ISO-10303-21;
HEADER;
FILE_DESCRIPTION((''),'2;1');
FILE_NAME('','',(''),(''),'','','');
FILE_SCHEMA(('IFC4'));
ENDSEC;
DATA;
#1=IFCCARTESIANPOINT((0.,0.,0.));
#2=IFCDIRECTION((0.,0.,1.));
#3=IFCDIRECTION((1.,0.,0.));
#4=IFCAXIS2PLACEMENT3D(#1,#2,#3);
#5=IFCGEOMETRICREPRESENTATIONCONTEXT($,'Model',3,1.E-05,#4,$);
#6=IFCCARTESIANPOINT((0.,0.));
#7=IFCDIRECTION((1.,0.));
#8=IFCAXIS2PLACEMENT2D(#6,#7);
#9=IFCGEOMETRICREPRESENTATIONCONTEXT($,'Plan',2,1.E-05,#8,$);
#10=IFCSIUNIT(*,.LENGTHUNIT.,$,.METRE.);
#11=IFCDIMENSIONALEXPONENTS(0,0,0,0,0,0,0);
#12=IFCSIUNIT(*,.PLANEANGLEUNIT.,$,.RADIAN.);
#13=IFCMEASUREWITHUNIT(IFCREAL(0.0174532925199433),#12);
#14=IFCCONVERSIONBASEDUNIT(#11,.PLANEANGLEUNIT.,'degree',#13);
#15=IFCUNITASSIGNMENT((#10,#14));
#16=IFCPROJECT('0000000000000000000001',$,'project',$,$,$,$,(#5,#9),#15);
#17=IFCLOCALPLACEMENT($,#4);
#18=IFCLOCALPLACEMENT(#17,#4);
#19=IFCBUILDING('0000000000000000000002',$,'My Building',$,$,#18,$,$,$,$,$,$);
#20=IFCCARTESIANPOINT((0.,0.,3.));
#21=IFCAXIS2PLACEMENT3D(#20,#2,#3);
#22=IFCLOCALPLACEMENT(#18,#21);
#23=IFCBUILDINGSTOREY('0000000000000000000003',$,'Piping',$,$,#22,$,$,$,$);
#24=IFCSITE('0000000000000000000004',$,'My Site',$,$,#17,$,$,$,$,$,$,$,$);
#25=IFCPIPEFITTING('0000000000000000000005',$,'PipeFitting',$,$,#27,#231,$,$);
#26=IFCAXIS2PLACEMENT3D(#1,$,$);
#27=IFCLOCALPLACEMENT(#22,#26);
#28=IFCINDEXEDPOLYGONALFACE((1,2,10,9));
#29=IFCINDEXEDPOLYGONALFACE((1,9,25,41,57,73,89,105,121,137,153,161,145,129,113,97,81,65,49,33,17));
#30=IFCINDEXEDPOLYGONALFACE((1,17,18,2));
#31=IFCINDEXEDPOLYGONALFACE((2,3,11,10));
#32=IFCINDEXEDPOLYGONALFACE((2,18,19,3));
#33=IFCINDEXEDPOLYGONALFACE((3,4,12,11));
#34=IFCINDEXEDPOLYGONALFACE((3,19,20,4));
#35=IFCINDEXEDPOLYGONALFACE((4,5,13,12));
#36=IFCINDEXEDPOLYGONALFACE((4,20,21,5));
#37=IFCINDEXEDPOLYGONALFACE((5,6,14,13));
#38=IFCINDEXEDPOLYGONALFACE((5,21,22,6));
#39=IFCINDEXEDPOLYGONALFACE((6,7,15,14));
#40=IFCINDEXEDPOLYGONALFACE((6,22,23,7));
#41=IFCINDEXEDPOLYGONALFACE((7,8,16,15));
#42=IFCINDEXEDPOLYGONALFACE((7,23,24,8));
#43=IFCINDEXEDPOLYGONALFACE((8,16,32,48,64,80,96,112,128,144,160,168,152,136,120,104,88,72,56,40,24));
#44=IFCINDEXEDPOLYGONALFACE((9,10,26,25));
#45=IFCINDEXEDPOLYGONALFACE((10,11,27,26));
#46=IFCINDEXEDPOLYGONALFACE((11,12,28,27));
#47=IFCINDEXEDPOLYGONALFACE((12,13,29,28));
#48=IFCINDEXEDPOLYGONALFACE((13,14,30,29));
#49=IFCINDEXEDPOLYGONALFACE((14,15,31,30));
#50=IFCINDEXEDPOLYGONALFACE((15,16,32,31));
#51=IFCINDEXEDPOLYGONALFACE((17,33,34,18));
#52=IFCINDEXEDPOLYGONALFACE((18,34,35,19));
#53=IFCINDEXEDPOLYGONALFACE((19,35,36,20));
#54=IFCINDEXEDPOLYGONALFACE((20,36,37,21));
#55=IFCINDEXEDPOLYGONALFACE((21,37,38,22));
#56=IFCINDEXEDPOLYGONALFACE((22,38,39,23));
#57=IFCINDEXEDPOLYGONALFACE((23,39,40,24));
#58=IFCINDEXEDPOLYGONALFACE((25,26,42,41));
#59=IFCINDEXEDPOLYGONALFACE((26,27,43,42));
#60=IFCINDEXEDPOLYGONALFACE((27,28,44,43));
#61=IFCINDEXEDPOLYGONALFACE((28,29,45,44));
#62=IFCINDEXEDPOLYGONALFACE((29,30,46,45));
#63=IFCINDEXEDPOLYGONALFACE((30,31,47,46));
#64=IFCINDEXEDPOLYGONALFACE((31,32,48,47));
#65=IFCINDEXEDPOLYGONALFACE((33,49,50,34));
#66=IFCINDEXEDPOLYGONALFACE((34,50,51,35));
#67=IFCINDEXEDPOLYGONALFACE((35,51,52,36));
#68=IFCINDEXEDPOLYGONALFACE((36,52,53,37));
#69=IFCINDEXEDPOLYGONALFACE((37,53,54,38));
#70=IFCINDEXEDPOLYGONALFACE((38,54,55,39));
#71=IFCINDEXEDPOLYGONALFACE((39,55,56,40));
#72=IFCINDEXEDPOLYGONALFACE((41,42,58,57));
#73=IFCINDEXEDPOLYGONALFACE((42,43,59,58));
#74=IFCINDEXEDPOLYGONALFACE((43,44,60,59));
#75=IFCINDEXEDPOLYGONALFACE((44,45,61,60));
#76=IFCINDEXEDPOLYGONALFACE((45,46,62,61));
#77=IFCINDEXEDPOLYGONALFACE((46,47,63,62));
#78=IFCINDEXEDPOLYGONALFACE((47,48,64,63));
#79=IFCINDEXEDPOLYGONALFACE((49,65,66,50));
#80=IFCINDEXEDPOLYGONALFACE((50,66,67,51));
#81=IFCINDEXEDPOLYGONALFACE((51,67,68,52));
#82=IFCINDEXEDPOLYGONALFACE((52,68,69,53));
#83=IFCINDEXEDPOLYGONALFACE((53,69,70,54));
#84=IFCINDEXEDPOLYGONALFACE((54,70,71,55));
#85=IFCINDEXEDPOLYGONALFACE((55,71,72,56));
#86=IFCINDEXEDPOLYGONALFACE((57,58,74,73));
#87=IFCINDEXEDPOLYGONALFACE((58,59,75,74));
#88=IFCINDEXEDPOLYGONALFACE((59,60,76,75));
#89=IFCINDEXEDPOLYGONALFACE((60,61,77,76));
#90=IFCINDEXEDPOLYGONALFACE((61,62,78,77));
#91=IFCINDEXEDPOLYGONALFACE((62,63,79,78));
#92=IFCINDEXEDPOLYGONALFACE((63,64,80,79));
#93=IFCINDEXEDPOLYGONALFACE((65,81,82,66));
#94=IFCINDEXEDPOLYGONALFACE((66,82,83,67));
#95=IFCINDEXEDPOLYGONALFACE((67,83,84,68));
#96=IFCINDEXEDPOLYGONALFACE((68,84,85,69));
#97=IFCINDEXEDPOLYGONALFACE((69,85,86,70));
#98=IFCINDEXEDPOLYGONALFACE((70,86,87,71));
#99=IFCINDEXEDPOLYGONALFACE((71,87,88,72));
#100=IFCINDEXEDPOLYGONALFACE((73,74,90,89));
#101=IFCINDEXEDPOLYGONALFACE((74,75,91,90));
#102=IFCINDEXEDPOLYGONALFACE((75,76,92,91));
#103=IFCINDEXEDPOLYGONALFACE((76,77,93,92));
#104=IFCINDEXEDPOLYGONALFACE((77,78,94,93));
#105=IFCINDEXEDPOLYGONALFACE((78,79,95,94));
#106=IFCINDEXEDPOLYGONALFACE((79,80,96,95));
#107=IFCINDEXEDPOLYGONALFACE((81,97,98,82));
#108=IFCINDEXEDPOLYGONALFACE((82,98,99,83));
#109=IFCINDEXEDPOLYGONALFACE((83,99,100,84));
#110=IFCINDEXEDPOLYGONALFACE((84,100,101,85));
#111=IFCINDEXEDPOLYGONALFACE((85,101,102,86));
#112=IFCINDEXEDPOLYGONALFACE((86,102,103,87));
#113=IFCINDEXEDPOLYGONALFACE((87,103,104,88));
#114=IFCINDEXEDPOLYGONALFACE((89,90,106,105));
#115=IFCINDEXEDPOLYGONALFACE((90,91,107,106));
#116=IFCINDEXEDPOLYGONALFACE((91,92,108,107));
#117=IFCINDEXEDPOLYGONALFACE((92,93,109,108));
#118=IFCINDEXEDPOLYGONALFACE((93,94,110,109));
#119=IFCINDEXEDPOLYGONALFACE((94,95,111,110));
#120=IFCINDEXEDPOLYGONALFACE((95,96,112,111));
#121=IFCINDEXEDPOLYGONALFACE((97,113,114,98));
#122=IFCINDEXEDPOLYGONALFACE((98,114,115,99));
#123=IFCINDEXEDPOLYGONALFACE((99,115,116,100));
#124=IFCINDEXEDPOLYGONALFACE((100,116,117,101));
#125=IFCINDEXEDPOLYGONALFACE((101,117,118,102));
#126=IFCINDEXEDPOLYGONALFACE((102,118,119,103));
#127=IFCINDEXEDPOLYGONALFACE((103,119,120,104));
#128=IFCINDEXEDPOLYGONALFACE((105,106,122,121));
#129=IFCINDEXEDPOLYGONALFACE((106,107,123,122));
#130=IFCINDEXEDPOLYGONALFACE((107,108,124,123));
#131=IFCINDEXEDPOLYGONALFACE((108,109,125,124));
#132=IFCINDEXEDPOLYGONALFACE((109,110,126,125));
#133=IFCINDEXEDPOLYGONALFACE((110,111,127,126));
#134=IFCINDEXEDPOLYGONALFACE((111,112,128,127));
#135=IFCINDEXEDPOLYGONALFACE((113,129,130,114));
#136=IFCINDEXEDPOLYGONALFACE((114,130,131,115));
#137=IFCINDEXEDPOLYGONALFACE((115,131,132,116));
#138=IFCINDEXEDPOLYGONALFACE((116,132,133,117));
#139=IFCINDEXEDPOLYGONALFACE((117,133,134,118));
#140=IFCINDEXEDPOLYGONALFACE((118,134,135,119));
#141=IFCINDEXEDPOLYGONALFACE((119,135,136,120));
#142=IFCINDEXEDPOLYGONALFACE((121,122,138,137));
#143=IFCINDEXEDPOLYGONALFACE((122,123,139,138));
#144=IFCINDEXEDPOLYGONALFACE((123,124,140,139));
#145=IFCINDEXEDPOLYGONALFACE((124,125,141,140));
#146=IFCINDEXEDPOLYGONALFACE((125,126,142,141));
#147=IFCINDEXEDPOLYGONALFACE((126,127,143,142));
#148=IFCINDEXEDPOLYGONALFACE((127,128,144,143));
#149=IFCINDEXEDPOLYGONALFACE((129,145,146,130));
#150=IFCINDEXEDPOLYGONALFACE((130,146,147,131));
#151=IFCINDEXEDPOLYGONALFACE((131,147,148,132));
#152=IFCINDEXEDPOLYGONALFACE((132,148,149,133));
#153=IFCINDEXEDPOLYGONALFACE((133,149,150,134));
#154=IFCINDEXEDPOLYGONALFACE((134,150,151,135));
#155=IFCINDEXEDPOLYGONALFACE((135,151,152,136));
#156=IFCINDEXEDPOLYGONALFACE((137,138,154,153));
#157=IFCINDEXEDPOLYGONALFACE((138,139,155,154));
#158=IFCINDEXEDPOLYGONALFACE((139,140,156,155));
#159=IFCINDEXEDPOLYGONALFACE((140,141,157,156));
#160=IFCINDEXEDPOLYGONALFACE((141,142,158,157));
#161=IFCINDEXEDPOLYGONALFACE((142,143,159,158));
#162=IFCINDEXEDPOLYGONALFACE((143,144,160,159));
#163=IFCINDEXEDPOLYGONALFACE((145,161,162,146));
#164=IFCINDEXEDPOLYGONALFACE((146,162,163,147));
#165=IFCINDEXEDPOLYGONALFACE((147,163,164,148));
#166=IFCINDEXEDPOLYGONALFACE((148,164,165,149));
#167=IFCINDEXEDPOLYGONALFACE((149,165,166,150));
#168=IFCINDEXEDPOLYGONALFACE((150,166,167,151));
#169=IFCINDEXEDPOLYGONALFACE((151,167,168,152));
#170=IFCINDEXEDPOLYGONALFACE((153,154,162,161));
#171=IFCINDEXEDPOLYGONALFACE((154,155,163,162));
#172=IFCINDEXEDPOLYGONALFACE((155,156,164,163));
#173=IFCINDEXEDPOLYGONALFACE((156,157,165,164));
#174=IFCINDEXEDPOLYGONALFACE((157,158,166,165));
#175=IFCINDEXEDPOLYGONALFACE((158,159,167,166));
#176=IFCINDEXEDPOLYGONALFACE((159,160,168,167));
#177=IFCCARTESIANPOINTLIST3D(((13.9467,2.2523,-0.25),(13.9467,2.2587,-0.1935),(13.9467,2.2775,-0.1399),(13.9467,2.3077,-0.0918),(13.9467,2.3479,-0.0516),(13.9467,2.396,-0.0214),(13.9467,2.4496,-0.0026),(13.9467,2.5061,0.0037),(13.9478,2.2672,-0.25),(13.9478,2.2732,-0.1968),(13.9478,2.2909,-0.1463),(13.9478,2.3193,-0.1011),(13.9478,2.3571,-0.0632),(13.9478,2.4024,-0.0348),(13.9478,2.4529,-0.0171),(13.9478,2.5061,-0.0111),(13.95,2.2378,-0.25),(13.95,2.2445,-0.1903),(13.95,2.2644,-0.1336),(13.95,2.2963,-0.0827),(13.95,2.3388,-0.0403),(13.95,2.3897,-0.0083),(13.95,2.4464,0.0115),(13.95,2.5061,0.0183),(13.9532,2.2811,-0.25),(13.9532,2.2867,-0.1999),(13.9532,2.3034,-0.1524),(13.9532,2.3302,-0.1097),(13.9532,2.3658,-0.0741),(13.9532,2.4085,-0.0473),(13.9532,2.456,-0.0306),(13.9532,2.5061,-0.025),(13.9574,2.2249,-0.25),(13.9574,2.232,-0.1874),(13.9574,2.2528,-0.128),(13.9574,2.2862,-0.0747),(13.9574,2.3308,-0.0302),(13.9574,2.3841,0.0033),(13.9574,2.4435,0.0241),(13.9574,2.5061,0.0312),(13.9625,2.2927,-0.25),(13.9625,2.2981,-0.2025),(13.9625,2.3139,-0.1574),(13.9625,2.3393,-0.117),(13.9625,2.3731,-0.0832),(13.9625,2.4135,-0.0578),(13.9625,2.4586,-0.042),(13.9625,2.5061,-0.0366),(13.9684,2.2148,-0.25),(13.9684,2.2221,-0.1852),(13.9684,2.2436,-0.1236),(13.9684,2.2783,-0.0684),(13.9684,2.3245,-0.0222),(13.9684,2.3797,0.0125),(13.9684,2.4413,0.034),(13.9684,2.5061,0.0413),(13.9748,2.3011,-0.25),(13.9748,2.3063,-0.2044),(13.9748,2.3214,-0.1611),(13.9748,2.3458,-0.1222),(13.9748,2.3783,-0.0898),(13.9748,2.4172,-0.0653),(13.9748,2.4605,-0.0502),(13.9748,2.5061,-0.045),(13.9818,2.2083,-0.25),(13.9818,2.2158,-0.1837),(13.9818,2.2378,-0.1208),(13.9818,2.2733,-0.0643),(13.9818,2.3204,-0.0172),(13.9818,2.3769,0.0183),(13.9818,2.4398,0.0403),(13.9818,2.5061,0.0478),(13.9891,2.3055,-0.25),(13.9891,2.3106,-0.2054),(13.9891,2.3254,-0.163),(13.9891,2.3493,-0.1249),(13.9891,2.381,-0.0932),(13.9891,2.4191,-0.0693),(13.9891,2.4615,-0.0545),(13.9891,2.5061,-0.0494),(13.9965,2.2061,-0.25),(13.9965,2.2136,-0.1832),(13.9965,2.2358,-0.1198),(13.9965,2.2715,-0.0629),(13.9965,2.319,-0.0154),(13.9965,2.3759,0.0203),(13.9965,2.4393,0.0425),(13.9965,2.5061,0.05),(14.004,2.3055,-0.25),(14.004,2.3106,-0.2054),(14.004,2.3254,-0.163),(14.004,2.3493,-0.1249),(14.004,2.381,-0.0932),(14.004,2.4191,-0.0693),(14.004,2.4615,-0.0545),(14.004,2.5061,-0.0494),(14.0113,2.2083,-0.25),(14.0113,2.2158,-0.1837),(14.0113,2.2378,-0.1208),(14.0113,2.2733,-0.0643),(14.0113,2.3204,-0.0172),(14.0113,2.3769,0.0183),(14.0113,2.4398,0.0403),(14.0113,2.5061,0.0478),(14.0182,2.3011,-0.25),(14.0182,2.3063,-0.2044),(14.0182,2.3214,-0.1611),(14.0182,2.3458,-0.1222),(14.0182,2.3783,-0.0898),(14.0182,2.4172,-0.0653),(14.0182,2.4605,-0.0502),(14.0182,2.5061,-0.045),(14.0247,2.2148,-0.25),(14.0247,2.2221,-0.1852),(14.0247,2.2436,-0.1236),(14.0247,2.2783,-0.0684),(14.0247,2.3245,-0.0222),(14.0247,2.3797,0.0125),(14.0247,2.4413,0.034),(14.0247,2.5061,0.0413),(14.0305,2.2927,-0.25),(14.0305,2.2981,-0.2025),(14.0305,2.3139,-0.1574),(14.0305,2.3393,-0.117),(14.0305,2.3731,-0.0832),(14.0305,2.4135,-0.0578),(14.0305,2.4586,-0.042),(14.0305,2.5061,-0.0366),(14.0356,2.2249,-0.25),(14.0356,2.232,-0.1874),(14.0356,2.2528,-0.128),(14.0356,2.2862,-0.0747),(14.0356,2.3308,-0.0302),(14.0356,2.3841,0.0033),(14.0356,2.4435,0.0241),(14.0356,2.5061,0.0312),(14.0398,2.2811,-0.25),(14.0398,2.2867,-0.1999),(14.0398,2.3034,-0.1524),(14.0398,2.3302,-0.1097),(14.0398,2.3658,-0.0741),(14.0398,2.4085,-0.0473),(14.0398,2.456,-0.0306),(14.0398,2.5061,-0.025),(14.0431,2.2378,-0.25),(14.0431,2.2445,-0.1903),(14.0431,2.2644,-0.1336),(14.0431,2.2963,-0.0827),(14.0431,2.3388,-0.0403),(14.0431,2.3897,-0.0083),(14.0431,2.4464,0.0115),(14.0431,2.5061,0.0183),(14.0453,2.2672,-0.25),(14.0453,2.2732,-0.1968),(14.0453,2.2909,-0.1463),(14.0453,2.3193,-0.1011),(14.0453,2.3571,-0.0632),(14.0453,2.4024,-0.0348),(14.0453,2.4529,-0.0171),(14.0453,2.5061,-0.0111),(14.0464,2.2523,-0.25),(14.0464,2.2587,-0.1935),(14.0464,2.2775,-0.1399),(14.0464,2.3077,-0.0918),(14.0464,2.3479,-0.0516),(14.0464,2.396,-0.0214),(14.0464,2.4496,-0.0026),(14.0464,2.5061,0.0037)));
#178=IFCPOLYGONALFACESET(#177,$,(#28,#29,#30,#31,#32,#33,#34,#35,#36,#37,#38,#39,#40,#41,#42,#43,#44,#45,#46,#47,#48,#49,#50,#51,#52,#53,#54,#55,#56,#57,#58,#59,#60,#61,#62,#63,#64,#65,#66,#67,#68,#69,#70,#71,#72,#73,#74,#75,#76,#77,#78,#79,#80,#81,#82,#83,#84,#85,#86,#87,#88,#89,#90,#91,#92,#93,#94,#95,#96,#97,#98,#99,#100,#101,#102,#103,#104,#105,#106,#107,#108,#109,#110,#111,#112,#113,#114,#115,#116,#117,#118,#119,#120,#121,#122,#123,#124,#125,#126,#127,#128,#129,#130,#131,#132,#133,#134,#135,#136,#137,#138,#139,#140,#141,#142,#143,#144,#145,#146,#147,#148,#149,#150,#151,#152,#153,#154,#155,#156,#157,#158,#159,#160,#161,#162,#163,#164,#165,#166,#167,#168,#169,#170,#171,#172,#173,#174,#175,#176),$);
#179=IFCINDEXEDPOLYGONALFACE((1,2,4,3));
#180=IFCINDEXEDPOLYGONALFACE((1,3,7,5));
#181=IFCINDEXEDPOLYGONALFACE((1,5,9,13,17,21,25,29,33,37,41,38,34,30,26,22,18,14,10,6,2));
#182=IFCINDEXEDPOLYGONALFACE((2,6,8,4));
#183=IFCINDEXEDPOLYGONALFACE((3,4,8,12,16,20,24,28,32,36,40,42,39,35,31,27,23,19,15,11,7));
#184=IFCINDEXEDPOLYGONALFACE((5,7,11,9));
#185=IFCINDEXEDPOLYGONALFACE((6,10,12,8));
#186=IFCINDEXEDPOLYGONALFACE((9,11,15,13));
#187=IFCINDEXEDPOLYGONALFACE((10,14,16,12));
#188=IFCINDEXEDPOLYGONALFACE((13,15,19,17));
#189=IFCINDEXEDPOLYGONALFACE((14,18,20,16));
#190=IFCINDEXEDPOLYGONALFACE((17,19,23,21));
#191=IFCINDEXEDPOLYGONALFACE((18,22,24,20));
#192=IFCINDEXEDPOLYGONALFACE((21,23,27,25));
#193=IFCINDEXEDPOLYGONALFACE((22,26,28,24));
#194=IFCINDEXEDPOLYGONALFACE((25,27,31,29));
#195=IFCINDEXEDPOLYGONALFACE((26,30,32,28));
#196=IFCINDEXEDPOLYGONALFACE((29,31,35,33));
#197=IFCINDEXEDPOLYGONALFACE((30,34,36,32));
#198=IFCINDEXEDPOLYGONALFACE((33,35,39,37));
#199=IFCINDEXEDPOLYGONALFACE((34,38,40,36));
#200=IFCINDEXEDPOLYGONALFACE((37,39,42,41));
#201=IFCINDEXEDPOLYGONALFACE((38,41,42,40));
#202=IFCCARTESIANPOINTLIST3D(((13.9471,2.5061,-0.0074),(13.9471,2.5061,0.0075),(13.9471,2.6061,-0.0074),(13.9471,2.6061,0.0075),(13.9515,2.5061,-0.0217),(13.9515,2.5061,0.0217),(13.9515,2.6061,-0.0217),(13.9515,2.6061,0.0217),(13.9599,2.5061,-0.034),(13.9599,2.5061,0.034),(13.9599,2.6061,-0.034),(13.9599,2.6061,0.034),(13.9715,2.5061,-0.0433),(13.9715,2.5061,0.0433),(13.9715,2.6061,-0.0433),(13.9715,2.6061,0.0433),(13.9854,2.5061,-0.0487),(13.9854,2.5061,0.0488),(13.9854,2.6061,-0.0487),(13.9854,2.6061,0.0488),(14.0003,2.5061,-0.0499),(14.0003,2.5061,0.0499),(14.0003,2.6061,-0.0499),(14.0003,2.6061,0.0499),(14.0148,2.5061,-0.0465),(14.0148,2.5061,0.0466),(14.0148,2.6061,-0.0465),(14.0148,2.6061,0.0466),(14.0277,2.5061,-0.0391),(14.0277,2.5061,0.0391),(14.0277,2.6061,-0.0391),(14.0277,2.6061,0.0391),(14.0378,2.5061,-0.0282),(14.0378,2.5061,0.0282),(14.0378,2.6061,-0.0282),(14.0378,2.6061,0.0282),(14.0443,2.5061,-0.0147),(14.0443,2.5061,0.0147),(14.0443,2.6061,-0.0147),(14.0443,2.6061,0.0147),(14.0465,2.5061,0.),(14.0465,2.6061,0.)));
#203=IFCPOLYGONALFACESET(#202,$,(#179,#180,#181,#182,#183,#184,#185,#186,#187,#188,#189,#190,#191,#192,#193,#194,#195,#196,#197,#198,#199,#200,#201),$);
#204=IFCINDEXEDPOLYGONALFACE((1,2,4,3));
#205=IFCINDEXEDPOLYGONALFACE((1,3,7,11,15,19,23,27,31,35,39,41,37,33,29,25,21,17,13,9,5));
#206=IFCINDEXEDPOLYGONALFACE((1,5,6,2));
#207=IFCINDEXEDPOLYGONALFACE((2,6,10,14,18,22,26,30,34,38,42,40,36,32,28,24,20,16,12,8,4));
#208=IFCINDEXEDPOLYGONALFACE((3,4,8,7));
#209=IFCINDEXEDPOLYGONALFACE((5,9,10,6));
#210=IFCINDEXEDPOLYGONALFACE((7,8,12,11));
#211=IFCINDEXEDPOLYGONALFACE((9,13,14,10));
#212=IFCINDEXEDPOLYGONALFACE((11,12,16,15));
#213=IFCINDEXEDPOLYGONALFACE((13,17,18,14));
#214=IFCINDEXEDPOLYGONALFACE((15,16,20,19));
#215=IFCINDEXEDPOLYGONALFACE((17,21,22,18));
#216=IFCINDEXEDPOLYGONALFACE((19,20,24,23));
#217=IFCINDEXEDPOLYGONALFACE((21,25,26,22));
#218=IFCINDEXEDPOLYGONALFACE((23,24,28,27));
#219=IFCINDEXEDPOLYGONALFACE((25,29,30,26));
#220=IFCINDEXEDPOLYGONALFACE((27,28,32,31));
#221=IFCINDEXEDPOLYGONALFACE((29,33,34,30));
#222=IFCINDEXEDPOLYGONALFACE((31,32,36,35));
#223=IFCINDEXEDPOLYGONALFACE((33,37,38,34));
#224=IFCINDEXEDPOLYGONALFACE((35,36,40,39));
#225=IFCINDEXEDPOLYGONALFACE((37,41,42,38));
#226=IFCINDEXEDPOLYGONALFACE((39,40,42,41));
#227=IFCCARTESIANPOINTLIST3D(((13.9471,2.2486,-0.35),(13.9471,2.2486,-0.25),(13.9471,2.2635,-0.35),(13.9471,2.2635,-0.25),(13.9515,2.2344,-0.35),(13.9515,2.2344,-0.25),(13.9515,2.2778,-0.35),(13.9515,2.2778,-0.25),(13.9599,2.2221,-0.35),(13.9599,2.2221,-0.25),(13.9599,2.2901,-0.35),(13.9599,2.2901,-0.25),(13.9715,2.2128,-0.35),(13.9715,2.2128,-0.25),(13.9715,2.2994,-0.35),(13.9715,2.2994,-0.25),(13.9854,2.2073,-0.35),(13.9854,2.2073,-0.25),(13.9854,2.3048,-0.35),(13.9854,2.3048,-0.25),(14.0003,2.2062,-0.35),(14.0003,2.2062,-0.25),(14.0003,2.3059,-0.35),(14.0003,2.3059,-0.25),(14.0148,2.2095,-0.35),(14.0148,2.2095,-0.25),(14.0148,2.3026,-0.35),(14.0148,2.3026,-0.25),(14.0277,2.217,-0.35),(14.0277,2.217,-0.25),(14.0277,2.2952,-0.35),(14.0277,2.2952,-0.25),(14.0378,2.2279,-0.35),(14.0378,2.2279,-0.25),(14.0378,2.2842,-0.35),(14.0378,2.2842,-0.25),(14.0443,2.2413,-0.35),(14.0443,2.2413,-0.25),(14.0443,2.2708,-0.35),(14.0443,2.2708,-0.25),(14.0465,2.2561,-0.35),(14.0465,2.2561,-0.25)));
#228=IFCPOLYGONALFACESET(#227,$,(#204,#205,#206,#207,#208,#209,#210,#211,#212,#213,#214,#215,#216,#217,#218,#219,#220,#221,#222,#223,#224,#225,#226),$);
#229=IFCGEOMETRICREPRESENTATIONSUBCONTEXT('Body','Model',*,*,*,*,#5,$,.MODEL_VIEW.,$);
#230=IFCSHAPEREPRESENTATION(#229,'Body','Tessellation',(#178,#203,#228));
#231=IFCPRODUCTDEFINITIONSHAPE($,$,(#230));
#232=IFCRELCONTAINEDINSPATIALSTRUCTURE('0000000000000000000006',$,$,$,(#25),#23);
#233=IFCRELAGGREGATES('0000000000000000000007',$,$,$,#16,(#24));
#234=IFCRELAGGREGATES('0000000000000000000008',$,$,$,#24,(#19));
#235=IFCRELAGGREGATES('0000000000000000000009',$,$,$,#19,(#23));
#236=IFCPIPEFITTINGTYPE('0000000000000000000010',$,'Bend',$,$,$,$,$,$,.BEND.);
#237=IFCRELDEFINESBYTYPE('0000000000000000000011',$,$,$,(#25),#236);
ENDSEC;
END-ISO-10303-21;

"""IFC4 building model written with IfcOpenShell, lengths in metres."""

from ifc_helpers import new_model, entity, si_unit, converted_unit, frame, origin_with_axes, origin_2d_with_axis, place, context, subcontext, project, spatial, circle, extrude, source, transform, mapped, type_object, type_shapes, element, save


model = new_model("IFC4")

# Units and contexts
model_context = context("Model", 3, precision=1e-05, world=origin_with_axes())
plan_context = context("Plan", 2, precision=1e-05, world=origin_2d_with_axis())
body_context = subcontext(model_context, "Body", "Model", "MODEL_VIEW")
ifc_project = project(units=[si_unit("LENGTHUNIT", "METRE"), converted_unit("PLANEANGLEUNIT", "degree", entity("IfcReal", 0.0174532925199433), si_unit("PLANEANGLEUNIT", "RADIAN"), dimensions=[0, 0, 0, 0, 0, 0, 0])], contexts=[model_context, plan_context])

# Site, building, storey
site_placement = place(None, origin_with_axes())
site = spatial("IfcSite", under=ifc_project, at=site_placement, Name="My Site")
building_placement = place(site_placement, origin_with_axes())
building = spatial("IfcBuilding", under=site, at=building_placement, Name="My Building")
storey_placement = place(building_placement, frame((0.0, 0.0, 3.0), z_axis=(0.0, 0.0, 1.0), x_axis=(1.0, 0.0, 0.0)))
storey = spatial("IfcBuildingStorey", under=building, at=storey_placement, Name="Piping")

# Pipe fitting
pipe_fitting_type = type_object("IfcPipeFittingType", Name="Bend", PredefinedType="BEND")
shared_shape = source(origin_with_axes(), body_context, "Body", "SolidModel", [
    entity("IfcSweptDiskSolid", entity("IfcIndexedPolyCurve", entity("IfcCartesianPointList3D", [[0.0, 0.0, 0.1], [0.0, -0.0732, 0.2768], [0.0, -0.25, 0.35]]), [entity("IfcArcIndex", [1, 2, 3])]), 0.05),
    extrude(circle(Radius=0.05), origin_with_axes(), (0.0, 0.0, 1.0), 0.1),
    extrude(circle(Radius=0.05), frame((0.0, -0.25, 0.35), z_axis=(0.0, -1.0, 0.0), x_axis=(1.0, 0.0, 0.0)), (0.0, 0.0, 1.0), 0.1),
])
type_shapes(pipe_fitting_type, [shared_shape])
for number, where, z_axis, x_axis, name in (
    (1, (13.9965, 2.6061, 0.0), (0.0, -1.0, 0.0), (1.0, 0.0, 0.0), "PipeFitting"),
):
    element("IfcPipeFitting", number, at=place(storey_placement, frame(where, z_axis=z_axis, x_axis=x_axis)), inside=storey, type_object=pipe_fitting_type, Name=name, context=body_context, shape_type="MappedRepresentation", body=[
        mapped(shared_shape, transform((0.0, 0.0, 0.0), x_axis=(1.0, 0.0, 0.0), y_axis=(0.0, 1.0, 0.0), z_axis=(0.0, 0.0, 1.0), scale=1.0)),
    ])

save(model, "model.ifc")
